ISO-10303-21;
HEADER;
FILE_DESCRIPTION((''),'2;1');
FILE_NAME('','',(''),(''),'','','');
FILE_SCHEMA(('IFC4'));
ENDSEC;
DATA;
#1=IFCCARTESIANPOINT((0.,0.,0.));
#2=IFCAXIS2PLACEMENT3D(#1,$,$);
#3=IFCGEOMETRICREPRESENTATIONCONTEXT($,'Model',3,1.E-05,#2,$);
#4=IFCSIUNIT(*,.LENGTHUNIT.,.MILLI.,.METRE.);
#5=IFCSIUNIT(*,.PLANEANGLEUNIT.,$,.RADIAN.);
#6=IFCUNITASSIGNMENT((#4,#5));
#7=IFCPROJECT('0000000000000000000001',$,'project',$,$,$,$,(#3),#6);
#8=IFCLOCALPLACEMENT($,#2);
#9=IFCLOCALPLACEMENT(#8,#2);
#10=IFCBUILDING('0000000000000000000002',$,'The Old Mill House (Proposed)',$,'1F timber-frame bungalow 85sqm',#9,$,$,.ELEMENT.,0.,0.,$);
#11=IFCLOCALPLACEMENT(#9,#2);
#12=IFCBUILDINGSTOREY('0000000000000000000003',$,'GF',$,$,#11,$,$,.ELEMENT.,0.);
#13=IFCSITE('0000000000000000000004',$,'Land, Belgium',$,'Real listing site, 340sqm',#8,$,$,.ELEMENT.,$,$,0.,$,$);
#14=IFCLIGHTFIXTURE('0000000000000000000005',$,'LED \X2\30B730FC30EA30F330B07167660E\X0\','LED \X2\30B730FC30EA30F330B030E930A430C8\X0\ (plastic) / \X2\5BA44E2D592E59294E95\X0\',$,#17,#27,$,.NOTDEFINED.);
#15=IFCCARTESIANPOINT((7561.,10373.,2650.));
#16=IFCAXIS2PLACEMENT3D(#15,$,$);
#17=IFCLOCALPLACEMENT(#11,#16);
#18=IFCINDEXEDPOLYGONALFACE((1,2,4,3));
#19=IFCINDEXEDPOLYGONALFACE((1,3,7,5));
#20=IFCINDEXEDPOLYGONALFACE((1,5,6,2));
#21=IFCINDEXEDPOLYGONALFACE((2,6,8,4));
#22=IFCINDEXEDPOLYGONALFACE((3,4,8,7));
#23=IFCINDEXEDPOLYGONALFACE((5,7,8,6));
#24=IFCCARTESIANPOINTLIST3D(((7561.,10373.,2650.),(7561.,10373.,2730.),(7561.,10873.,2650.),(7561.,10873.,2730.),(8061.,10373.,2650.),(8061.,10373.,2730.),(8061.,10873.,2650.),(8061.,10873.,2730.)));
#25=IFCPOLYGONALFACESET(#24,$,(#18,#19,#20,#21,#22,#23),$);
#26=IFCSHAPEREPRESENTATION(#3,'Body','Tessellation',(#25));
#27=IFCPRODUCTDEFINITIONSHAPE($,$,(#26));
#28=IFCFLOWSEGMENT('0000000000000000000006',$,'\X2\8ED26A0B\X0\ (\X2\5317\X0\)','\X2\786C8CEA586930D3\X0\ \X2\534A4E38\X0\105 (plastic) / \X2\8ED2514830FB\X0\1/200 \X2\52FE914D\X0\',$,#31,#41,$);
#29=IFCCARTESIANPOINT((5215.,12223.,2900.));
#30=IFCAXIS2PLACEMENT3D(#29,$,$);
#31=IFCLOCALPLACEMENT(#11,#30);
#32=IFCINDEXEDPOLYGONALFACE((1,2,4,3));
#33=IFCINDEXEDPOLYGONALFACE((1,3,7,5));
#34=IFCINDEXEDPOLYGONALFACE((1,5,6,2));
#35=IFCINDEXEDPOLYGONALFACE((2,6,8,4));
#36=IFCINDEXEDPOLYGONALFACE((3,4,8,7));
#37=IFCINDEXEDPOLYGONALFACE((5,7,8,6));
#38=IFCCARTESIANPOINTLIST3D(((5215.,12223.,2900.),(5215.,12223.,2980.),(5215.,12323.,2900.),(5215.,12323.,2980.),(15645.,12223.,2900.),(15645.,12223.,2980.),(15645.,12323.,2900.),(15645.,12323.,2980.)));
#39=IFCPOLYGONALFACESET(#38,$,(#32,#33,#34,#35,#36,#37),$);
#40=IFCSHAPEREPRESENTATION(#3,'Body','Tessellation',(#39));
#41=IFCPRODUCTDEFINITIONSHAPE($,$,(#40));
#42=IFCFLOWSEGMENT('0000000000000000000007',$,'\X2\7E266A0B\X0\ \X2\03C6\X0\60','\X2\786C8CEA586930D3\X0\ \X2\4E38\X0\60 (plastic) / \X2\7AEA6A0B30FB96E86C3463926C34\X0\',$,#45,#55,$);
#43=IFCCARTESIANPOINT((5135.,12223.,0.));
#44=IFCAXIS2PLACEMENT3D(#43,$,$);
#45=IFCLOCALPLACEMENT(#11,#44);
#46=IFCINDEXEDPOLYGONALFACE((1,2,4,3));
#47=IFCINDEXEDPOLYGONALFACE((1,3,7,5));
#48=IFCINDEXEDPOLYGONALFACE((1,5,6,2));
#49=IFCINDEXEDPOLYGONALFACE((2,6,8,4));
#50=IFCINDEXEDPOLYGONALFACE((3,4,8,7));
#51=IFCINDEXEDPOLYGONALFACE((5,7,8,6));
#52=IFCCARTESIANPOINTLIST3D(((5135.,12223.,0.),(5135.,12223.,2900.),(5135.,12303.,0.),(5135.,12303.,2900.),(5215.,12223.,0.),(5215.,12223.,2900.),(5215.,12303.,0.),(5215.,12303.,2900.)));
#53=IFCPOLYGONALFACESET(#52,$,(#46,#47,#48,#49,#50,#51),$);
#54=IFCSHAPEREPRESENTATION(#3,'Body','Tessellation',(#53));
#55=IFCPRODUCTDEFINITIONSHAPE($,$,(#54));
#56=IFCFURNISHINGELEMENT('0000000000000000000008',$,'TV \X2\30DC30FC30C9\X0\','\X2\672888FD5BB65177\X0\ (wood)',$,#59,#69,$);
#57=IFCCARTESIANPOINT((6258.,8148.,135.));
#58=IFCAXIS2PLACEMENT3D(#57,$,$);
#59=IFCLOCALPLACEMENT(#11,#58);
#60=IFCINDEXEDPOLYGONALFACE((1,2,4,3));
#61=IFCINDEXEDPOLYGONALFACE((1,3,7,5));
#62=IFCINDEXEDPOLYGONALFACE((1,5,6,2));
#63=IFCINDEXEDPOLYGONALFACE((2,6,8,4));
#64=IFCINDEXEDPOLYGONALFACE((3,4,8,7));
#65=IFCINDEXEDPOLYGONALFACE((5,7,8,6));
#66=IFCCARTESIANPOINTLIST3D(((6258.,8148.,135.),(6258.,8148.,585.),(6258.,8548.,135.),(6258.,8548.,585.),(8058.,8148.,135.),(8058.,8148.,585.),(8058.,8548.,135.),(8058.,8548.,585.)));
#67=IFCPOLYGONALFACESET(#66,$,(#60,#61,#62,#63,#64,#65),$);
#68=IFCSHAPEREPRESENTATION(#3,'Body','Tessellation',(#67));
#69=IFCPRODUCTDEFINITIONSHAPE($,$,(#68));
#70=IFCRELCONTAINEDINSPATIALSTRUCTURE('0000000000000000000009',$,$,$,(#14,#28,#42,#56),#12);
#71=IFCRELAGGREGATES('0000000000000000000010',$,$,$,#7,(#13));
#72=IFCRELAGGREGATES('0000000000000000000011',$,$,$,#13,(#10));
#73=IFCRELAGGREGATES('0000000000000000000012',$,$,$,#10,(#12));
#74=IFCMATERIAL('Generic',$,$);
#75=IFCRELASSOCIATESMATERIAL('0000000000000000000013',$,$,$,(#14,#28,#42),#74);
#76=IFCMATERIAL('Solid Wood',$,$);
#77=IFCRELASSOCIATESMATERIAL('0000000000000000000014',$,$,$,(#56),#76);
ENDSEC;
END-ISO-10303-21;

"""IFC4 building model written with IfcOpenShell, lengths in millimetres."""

from ifc_helpers import new_model, si_unit, frame, frame_2d, origin, place, context, project, spatial, rectangle, extrude, material, element, save


model = new_model("IFC4")

# Units and contexts
model_context = context("Model", 3, precision=1e-05, world=origin())
ifc_project = project(units=[si_unit("LENGTHUNIT", "METRE", prefix="MILLI"), si_unit("PLANEANGLEUNIT", "RADIAN")], contexts=[model_context])

# Site, building, storey
site_placement = place(None, origin())
site = spatial("IfcSite", under=ifc_project, at=site_placement, Name="Land, Belgium", ObjectType="Real listing site, 340sqm", CompositionType="ELEMENT", RefElevation=0.0)
building_placement = place(site_placement, origin())
building = spatial("IfcBuilding", under=site, at=building_placement, Name="The Old Mill House (Proposed)", ObjectType="1F timber-frame bungalow 85sqm", CompositionType="ELEMENT", ElevationOfRefHeight=0.0, ElevationOfTerrain=0.0)
storey_placement = place(building_placement, origin())
storey = spatial("IfcBuildingStorey", under=building, at=storey_placement, Name="GF", CompositionType="ELEMENT", Elevation=0.0)

# Shared definitions
ifc_material_1 = material(Name="Solid Wood")

# Shared definitions
ifc_material_2 = material(Name="Generic")

# Light fixture
light_fixture_placement = place(storey_placement, frame((7561.0, 10373.0, 2650.0)))
element("IfcLightFixture", 1, at=light_fixture_placement, inside=storey, material=ifc_material_2, Name="LED シーリング照明", Description="LED シーリングライト (plastic) / 室中央天井", PredefinedType="NOTDEFINED", context=model_context, shape_type="SweptSolid", body=[
    extrude(rectangle(XDim=500.0, YDim=500.0, at=frame_2d((250.0, 250.0))), frame((7561.0, 10373.0, 2650.0)), (0.0, 0.0, 1.0), 80.0),
])

# Flow segments
flow_segment_1_placement = place(storey_placement, frame((5215.0, 12223.0, 2900.0)))
element("IfcFlowSegment", 2, at=flow_segment_1_placement, inside=storey, material=ifc_material_2, Name="軒樋 (北)", Description="硬質塩ビ 半丸105 (plastic) / 軒先・1/200 勾配", context=model_context, shape_type="SweptSolid", body=[
    extrude(rectangle(XDim=10430.0, YDim=100.0, at=frame_2d((5215.0, 50.0))), frame((5215.0, 12223.0, 2900.0)), (0.0, 0.0, 1.0), 80.0),
])
flow_segment_2_placement = place(storey_placement, frame((5135.0, 12223.0, 0.0)))
element("IfcFlowSegment", 3, at=flow_segment_2_placement, inside=storey, material=ifc_material_2, Name="縦樋 φ60", Description="硬質塩ビ 丸60 (plastic) / 竪樋・雨水排水", context=model_context, shape_type="SweptSolid", body=[
    extrude(rectangle(XDim=80.0, YDim=80.0, at=frame_2d((40.0, 40.0))), frame((5135.0, 12223.0, 0.0)), (0.0, 0.0, 1.0), 2900.0),
])

# Furnishing element
furnishing_placement = place(storey_placement, frame((6258.0, 8148.0, 135.0)))
element("IfcFurnishingElement", 4, at=furnishing_placement, inside=storey, material=ifc_material_1, Name="TV ボード", Description="木製家具 (wood)", context=model_context, shape_type="SweptSolid", body=[
    extrude(rectangle(XDim=1800.0, YDim=400.0, at=frame_2d((900.0, 200.0))), frame((6258.0, 8148.0, 135.0)), (0.0, 0.0, 1.0), 450.0),
])

save(model, "model.ifc")
